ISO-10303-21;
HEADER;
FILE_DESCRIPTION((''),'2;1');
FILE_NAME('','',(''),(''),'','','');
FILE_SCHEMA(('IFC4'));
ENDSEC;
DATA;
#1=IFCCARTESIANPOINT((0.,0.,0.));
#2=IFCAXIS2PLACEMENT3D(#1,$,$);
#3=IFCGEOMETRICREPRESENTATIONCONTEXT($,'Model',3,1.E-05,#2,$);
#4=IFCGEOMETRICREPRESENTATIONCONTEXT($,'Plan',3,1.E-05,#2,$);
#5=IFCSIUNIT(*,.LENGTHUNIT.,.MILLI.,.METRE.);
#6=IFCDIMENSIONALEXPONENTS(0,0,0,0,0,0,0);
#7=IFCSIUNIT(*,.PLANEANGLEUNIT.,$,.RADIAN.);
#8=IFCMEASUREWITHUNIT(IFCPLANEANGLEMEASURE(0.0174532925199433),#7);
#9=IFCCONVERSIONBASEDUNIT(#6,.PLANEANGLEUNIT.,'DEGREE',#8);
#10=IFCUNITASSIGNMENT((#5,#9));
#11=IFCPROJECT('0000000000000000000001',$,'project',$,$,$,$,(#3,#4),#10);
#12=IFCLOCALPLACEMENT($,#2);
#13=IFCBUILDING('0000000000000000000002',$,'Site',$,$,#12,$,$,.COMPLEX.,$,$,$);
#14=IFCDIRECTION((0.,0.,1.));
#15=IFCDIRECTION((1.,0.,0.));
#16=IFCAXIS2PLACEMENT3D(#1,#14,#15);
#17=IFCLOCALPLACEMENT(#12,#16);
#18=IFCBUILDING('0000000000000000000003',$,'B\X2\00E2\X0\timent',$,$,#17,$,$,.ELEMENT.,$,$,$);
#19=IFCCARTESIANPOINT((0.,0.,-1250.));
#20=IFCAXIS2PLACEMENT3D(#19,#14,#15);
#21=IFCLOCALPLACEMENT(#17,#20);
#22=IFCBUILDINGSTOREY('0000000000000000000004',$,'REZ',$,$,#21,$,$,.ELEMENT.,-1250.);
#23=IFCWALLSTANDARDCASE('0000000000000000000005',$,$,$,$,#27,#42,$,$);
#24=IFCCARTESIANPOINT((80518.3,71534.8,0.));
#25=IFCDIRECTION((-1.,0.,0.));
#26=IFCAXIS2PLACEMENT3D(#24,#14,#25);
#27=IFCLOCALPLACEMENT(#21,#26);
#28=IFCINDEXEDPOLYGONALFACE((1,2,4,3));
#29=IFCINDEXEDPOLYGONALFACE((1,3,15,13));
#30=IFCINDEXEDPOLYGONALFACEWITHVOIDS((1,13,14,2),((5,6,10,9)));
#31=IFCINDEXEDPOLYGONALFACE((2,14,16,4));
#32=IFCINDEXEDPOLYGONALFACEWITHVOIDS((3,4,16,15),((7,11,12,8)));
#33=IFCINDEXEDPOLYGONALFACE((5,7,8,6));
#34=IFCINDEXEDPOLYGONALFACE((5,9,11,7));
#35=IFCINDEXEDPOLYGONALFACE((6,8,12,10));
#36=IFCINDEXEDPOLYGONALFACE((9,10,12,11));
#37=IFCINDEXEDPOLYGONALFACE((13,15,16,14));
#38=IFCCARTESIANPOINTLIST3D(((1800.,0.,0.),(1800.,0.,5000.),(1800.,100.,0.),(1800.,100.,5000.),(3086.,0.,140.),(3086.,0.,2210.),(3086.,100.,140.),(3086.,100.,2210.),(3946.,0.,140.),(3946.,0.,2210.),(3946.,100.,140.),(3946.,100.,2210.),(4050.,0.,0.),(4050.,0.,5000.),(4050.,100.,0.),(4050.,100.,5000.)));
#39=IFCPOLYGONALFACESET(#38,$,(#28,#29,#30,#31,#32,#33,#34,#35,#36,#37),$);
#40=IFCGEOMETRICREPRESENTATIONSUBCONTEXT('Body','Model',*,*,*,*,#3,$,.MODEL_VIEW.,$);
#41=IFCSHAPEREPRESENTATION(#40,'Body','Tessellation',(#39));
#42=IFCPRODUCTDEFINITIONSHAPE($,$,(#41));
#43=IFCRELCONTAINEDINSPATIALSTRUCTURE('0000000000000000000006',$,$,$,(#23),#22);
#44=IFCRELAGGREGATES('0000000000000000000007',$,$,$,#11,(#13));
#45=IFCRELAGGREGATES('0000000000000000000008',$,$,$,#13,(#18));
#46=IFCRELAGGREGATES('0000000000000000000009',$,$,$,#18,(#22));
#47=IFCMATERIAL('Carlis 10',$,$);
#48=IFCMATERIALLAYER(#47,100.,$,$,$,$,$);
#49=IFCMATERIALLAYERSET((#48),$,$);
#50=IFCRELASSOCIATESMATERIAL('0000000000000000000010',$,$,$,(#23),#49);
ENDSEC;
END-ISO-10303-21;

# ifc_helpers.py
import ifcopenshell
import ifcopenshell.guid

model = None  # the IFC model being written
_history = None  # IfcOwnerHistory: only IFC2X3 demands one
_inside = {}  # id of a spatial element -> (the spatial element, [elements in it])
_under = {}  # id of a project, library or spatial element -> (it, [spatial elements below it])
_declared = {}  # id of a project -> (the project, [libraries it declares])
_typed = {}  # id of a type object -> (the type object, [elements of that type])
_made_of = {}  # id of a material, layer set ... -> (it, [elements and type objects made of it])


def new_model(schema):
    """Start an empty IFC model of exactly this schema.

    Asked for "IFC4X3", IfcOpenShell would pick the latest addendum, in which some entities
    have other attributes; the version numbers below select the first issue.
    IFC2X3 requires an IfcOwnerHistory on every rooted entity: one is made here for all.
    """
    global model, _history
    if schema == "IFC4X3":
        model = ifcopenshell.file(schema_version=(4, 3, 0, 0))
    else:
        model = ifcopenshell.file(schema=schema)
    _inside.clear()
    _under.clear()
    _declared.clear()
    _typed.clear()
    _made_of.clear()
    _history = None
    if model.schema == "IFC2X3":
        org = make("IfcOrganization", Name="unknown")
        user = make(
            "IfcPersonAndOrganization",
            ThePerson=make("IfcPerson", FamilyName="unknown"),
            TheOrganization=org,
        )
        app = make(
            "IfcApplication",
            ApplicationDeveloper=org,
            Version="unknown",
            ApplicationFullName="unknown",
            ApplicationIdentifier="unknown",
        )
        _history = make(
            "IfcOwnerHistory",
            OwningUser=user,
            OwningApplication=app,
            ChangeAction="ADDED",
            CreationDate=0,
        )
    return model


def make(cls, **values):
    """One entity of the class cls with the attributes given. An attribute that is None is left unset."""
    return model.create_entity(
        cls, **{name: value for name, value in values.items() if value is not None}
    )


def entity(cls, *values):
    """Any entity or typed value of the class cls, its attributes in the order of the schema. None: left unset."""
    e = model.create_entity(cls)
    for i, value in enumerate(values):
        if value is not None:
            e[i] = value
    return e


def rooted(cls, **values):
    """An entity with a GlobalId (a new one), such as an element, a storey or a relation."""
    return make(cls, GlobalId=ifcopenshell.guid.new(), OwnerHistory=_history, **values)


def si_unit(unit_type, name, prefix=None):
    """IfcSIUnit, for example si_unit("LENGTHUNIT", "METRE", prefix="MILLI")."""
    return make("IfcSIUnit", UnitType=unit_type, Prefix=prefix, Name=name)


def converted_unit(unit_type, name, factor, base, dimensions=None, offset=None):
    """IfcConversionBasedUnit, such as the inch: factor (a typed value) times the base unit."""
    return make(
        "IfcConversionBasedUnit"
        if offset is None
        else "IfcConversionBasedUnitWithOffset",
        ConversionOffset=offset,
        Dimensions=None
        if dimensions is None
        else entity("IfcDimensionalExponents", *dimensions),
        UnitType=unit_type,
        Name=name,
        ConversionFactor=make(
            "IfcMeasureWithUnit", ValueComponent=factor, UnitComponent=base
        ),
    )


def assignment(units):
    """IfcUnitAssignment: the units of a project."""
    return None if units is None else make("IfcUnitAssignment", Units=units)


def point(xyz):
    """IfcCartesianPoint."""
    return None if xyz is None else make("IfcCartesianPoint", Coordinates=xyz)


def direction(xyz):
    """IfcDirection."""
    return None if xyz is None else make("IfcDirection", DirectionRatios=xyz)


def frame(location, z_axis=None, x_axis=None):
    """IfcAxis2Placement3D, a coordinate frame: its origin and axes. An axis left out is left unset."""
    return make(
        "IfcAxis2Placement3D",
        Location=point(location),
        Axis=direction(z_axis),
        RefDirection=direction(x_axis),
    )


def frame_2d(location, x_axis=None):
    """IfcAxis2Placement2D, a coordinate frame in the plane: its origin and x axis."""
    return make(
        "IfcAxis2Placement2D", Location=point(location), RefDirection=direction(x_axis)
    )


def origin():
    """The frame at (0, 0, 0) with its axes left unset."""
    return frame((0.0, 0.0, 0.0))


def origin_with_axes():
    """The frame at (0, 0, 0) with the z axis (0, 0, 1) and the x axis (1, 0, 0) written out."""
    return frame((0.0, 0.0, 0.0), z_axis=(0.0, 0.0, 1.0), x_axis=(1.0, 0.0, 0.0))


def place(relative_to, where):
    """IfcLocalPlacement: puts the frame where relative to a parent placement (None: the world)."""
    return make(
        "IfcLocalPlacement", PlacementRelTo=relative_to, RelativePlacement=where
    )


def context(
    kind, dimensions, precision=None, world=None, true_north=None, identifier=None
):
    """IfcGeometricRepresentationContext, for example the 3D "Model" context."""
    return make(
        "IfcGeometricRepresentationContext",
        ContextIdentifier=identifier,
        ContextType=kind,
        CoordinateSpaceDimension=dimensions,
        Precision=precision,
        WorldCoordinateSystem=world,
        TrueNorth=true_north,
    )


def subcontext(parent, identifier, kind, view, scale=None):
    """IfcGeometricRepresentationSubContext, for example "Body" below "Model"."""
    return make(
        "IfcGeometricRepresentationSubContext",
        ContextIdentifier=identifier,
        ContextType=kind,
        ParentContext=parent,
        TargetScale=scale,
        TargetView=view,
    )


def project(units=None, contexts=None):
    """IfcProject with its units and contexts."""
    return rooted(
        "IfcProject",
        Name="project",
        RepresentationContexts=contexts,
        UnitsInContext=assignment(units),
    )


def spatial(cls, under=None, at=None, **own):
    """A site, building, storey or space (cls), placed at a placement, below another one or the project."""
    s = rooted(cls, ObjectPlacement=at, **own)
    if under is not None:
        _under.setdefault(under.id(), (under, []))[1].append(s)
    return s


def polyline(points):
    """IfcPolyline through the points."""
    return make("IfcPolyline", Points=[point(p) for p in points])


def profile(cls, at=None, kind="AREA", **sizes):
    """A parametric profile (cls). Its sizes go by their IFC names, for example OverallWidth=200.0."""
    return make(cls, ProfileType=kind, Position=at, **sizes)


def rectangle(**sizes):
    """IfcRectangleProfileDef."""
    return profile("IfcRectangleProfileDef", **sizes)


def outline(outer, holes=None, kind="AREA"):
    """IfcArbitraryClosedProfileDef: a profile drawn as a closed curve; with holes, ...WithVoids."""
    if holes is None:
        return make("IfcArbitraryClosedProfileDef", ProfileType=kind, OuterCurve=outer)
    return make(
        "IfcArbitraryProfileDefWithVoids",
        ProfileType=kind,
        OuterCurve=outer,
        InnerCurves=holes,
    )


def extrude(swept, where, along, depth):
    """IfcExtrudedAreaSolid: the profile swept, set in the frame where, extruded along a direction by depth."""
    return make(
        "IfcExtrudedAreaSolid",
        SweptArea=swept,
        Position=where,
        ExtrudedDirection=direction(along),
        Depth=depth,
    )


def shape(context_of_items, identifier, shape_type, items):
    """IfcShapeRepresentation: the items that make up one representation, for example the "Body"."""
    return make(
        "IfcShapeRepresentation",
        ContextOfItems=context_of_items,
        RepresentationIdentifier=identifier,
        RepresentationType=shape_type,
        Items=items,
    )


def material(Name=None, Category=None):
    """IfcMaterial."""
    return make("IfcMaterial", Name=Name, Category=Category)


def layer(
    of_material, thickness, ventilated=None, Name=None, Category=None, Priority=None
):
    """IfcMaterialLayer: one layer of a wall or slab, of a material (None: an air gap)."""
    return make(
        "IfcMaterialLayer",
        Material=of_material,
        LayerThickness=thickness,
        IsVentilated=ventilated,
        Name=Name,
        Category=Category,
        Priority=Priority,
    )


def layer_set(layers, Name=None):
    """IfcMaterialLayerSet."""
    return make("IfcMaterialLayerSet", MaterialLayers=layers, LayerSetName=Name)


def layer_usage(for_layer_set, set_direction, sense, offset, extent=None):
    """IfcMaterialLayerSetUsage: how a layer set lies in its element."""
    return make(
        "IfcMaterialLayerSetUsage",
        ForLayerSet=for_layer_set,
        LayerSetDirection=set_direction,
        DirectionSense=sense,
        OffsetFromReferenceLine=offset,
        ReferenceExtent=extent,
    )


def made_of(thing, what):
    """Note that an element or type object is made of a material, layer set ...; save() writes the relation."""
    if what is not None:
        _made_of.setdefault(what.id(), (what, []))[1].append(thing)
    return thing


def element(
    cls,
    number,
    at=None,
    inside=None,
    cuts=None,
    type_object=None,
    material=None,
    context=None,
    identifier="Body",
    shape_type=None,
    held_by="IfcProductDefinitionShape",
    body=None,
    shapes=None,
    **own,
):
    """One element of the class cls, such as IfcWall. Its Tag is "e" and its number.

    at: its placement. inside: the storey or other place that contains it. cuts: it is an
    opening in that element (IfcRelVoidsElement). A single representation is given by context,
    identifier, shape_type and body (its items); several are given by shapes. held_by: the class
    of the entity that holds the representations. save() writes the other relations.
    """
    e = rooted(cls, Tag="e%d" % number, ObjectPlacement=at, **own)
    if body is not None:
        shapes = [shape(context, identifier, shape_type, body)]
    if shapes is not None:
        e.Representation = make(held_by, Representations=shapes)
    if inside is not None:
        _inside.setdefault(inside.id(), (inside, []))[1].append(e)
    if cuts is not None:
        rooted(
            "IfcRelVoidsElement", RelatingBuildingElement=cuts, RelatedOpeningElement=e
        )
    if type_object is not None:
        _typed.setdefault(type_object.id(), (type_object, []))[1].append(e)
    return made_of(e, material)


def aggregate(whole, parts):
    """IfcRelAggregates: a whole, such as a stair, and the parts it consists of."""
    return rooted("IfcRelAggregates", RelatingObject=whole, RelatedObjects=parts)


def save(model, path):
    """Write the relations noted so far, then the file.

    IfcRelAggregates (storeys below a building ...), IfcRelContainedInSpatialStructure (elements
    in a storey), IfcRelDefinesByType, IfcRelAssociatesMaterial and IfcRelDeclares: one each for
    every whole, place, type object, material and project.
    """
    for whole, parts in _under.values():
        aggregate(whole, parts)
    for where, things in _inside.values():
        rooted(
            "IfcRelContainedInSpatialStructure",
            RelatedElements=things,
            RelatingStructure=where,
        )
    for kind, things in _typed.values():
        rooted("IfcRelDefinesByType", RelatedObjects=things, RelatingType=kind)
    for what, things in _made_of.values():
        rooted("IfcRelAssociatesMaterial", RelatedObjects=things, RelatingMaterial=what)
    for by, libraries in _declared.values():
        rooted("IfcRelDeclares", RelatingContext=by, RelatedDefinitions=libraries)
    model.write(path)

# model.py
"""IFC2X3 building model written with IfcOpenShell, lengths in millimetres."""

from ifc_helpers import new_model, entity, si_unit, converted_unit, frame, frame_2d, origin, origin_with_axes, place, context, subcontext, project, spatial, polyline, rectangle, outline, extrude, material, layer, layer_set, layer_usage, element, save


model = new_model("IFC2X3")

# Units and contexts
model_context = context("Model", 3, precision=1e-05, world=origin())
plan_context = context("Plan", 3, precision=1e-05, world=origin())
body_context = subcontext(model_context, "Body", "Model", "MODEL_VIEW")
ifc_project = project(units=[si_unit("LENGTHUNIT", "METRE", prefix="MILLI"), converted_unit("PLANEANGLEUNIT", "DEGREE", entity("IfcPlaneAngleMeasure", 0.0174532925199433), si_unit("PLANEANGLEUNIT", "RADIAN"), dimensions=[0, 0, 0, 0, 0, 0, 0])], contexts=[model_context, plan_context])

# Buildings, storey
building_1_placement = place(None, origin())
building_1 = spatial("IfcBuilding", under=ifc_project, at=building_1_placement, Name="Site", CompositionType="COMPLEX")
building_2_placement = place(building_1_placement, origin_with_axes())
building_2 = spatial("IfcBuilding", under=building_1, at=building_2_placement, Name="Bâtiment", CompositionType="ELEMENT")
storey_placement = place(building_2_placement, frame((0.0, 0.0, -1250.0), z_axis=(0.0, 0.0, 1.0), x_axis=(1.0, 0.0, 0.0)))
storey = spatial("IfcBuildingStorey", under=building_2, at=storey_placement, Name="REZ", CompositionType="ELEMENT", Elevation=-1250.0)

# Wall, opening
ifc_material_1 = material(Name="Carlis 10")
ifc_layer_1 = layer(ifc_material_1, 100.0)
ifc_layer_set_1 = layer_set([ifc_layer_1])
ifc_layer_usage_1 = layer_usage(ifc_layer_set_1, "AXIS2", "POSITIVE", 0.0)
wall_1_placement = place(storey_placement, frame((80518.3, 71534.8, 0.0), z_axis=(0.0, 0.0, 1.0), x_axis=(-1.0, 0.0, 0.0)))
wall_1 = element("IfcWallStandardCase", 1, at=wall_1_placement, inside=storey, material=ifc_layer_usage_1, context=body_context, shape_type="SweptSolid", body=[
    extrude(outline(polyline([(1800.0, 0.0), (4050.0, 0.0), (4050.0, 100.0), (1800.0, 100.0), (1800.0, 0.0)])), origin_with_axes(), (0.0, 0.0, 1.0), 5000.0),
])
opening_1_placement = place(wall_1_placement, frame((3086.0, 0.0, 140.0), z_axis=(0.0, 1.0, 0.0), x_axis=(0.0, 0.0, 1.0)))
element("IfcOpeningElement", 2, at=opening_1_placement, cuts=wall_1, ObjectType="Opening", context=body_context, shape_type="SweptSolid", body=[
    extrude(rectangle(XDim=2070.0, YDim=860.0, at=frame_2d((1035.0, 430.0), x_axis=(1.0, 0.0))), origin_with_axes(), (0.0, 0.0, 1.0), 100.0),
])

save(model, "model.ifc")
